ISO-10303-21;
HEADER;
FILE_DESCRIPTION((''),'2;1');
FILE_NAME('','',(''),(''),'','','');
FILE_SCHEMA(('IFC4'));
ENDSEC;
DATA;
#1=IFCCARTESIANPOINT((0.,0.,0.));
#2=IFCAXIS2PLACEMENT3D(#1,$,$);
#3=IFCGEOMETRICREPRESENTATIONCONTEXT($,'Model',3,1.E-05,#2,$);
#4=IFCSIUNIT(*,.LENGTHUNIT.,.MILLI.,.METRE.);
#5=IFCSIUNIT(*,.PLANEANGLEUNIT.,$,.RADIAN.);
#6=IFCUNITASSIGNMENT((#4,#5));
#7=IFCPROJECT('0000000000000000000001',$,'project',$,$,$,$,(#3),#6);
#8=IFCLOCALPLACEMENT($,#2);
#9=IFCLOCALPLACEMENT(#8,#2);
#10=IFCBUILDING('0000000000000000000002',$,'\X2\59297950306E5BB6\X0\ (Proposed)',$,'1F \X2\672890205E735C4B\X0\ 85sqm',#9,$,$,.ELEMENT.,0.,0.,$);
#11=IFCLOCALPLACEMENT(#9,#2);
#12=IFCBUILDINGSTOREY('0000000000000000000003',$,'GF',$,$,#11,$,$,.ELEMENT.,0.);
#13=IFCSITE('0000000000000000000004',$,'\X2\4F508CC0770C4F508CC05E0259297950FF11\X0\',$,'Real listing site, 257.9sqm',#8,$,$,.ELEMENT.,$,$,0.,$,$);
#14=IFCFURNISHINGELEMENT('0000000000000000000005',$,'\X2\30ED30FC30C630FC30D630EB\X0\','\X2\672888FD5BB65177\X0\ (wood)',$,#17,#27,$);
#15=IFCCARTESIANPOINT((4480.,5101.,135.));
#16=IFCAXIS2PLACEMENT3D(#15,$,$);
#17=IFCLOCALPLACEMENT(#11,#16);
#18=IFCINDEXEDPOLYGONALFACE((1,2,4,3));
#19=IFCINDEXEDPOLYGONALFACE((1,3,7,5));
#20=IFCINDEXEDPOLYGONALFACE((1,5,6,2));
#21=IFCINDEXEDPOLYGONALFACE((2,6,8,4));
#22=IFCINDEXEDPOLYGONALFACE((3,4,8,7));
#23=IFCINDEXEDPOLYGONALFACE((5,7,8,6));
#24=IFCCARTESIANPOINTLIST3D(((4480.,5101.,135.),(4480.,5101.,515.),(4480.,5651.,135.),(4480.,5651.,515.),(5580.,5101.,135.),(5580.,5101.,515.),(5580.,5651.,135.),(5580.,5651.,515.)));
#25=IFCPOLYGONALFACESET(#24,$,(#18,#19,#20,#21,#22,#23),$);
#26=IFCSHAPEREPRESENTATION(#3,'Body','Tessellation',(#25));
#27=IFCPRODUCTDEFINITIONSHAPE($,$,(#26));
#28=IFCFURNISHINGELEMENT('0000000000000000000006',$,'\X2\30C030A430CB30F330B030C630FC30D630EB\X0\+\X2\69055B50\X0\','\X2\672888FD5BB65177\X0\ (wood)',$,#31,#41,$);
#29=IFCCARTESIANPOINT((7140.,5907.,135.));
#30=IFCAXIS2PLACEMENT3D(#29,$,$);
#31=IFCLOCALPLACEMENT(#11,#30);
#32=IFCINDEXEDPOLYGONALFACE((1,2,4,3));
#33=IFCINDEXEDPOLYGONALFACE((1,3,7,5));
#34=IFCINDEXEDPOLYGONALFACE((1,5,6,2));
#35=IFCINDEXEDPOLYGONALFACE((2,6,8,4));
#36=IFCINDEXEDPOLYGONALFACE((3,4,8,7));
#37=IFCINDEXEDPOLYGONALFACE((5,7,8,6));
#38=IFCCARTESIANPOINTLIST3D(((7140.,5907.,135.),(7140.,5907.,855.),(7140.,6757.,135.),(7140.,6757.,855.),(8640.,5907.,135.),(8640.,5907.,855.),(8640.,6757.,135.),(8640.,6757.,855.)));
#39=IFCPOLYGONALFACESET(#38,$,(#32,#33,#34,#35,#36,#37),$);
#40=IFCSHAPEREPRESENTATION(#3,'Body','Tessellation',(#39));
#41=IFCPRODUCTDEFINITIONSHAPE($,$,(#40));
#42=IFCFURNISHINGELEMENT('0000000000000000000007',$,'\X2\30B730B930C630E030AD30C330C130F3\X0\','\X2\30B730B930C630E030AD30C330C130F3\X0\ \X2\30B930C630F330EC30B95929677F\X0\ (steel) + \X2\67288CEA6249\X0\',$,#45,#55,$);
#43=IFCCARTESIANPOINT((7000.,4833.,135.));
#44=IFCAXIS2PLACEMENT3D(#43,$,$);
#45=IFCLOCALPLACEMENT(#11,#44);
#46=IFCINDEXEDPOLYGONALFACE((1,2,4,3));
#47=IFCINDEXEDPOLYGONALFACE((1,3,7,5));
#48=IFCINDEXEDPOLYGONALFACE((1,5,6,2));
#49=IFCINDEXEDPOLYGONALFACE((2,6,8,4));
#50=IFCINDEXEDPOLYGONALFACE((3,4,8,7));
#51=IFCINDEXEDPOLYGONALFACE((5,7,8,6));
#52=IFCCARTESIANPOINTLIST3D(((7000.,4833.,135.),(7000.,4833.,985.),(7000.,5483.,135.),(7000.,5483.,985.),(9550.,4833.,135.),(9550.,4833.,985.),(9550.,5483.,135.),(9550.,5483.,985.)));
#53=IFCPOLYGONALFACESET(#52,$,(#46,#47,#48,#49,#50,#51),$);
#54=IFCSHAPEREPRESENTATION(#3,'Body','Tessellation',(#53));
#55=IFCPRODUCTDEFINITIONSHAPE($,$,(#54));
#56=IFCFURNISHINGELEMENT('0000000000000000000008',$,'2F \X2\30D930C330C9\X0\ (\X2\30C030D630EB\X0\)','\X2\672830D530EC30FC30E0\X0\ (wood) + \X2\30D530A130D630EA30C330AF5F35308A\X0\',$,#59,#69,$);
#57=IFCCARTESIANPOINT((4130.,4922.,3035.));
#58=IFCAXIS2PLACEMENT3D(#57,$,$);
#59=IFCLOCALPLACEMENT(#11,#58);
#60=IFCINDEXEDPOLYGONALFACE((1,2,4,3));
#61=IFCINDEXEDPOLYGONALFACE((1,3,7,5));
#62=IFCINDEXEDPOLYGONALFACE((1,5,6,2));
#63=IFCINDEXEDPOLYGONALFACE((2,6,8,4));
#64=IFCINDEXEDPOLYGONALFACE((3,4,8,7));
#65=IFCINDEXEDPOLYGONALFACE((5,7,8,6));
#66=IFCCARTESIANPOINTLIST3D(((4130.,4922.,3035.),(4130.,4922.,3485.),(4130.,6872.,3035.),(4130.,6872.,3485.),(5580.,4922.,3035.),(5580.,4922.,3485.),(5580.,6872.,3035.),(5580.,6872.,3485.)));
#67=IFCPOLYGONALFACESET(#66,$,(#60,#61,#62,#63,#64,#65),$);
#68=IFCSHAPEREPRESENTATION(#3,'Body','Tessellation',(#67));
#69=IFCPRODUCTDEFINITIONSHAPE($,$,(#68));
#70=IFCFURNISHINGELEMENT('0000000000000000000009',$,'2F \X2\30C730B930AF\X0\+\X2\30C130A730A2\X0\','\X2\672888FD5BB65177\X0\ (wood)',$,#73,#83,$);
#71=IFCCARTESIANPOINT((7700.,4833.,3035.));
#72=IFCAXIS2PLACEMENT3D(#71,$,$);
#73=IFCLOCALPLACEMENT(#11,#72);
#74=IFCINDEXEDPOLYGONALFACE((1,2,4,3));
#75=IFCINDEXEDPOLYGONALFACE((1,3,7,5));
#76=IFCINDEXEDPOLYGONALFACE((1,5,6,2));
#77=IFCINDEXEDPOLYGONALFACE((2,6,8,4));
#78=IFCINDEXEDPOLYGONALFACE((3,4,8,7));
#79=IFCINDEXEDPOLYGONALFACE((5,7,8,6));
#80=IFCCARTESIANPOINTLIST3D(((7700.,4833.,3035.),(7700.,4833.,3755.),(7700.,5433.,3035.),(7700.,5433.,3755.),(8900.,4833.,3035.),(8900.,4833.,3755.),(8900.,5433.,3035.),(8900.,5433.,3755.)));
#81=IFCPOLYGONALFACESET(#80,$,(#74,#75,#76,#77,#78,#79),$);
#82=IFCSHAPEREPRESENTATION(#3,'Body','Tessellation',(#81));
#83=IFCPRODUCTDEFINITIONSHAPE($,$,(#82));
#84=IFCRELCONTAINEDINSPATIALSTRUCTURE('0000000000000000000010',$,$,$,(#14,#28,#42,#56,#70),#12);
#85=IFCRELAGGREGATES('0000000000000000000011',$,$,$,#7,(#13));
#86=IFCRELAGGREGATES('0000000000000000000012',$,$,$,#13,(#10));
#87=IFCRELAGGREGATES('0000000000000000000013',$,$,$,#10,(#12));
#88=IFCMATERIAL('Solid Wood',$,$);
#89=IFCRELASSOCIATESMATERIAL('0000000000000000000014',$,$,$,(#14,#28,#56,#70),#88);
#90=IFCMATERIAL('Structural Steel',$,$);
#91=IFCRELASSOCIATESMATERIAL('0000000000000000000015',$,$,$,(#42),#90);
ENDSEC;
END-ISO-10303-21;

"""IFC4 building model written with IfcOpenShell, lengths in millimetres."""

from ifc_helpers import new_model, si_unit, frame, frame_2d, origin, place, context, project, spatial, rectangle, extrude, material, element, save


model = new_model("IFC4")

# Units and contexts
model_context = context("Model", 3, precision=1e-05, world=origin())
ifc_project = project(units=[si_unit("LENGTHUNIT", "METRE", prefix="MILLI"), si_unit("PLANEANGLEUNIT", "RADIAN")], contexts=[model_context])

# Site, building, storey
site_placement = place(None, origin())
site = spatial("IfcSite", under=ifc_project, at=site_placement, Name="佐賀県佐賀市天祐１", ObjectType="Real listing site, 257.9sqm", CompositionType="ELEMENT", RefElevation=0.0)
building_placement = place(site_placement, origin())
building = spatial("IfcBuilding", under=site, at=building_placement, Name="天祐の家 (Proposed)", ObjectType="1F 木造平屋 85sqm", CompositionType="ELEMENT", ElevationOfRefHeight=0.0, ElevationOfTerrain=0.0)
storey_placement = place(building_placement, origin())
storey = spatial("IfcBuildingStorey", under=building, at=storey_placement, Name="GF", CompositionType="ELEMENT", Elevation=0.0)

# Shared definitions
ifc_material_1 = material(Name="Solid Wood")

# Shared definitions
ifc_material_2 = material(Name="Structural Steel")

# Furnishing elements
furnishing_1_placement = place(storey_placement, frame((4480.0, 5101.0, 135.0)))
element("IfcFurnishingElement", 1, at=furnishing_1_placement, inside=storey, material=ifc_material_1, Name="ローテーブル", Description="木製家具 (wood)", context=model_context, shape_type="SweptSolid", body=[
    extrude(rectangle(XDim=1100.0, YDim=550.0, at=frame_2d((550.0, 275.0))), frame((4480.0, 5101.0, 135.0)), (0.0, 0.0, 1.0), 380.0),
])
furnishing_2_placement = place(storey_placement, frame((7140.0, 5907.0, 135.0)))
element("IfcFurnishingElement", 2, at=furnishing_2_placement, inside=storey, material=ifc_material_1, Name="ダイニングテーブル+椅子", Description="木製家具 (wood)", context=model_context, shape_type="SweptSolid", body=[
    extrude(rectangle(XDim=1500.0, YDim=850.0, at=frame_2d((750.0, 425.0))), frame((7140.0, 5907.0, 135.0)), (0.0, 0.0, 1.0), 720.0),
])
furnishing_3_placement = place(storey_placement, frame((7000.0, 4833.0, 135.0)))
element("IfcFurnishingElement", 3, at=furnishing_3_placement, inside=storey, material=ifc_material_2, Name="システムキッチン", Description="システムキッチン ステンレス天板 (steel) + 木質扉", context=model_context, shape_type="SweptSolid", body=[
    extrude(rectangle(XDim=2550.0, YDim=650.0, at=frame_2d((1275.0, 325.0))), frame((7000.0, 4833.0, 135.0)), (0.0, 0.0, 1.0), 850.0),
])
furnishing_4_placement = place(storey_placement, frame((4130.0, 4922.0, 3035.0)))
element("IfcFurnishingElement", 4, at=furnishing_4_placement, inside=storey, material=ifc_material_1, Name="2F ベッド (ダブル)", Description="木フレーム (wood) + ファブリック張り", context=model_context, shape_type="SweptSolid", body=[
    extrude(rectangle(XDim=1450.0, YDim=1950.0, at=frame_2d((725.0, 975.0))), frame((4130.0, 4922.0, 3035.0)), (0.0, 0.0, 1.0), 450.0),
])
furnishing_5_placement = place(storey_placement, frame((7700.0, 4833.0, 3035.0)))
element("IfcFurnishingElement", 5, at=furnishing_5_placement, inside=storey, material=ifc_material_1, Name="2F デスク+チェア", Description="木製家具 (wood)", context=model_context, shape_type="SweptSolid", body=[
    extrude(rectangle(XDim=1200.0, YDim=600.0, at=frame_2d((600.0, 300.0))), frame((7700.0, 4833.0, 3035.0)), (0.0, 0.0, 1.0), 720.0),
])

save(model, "model.ifc")
